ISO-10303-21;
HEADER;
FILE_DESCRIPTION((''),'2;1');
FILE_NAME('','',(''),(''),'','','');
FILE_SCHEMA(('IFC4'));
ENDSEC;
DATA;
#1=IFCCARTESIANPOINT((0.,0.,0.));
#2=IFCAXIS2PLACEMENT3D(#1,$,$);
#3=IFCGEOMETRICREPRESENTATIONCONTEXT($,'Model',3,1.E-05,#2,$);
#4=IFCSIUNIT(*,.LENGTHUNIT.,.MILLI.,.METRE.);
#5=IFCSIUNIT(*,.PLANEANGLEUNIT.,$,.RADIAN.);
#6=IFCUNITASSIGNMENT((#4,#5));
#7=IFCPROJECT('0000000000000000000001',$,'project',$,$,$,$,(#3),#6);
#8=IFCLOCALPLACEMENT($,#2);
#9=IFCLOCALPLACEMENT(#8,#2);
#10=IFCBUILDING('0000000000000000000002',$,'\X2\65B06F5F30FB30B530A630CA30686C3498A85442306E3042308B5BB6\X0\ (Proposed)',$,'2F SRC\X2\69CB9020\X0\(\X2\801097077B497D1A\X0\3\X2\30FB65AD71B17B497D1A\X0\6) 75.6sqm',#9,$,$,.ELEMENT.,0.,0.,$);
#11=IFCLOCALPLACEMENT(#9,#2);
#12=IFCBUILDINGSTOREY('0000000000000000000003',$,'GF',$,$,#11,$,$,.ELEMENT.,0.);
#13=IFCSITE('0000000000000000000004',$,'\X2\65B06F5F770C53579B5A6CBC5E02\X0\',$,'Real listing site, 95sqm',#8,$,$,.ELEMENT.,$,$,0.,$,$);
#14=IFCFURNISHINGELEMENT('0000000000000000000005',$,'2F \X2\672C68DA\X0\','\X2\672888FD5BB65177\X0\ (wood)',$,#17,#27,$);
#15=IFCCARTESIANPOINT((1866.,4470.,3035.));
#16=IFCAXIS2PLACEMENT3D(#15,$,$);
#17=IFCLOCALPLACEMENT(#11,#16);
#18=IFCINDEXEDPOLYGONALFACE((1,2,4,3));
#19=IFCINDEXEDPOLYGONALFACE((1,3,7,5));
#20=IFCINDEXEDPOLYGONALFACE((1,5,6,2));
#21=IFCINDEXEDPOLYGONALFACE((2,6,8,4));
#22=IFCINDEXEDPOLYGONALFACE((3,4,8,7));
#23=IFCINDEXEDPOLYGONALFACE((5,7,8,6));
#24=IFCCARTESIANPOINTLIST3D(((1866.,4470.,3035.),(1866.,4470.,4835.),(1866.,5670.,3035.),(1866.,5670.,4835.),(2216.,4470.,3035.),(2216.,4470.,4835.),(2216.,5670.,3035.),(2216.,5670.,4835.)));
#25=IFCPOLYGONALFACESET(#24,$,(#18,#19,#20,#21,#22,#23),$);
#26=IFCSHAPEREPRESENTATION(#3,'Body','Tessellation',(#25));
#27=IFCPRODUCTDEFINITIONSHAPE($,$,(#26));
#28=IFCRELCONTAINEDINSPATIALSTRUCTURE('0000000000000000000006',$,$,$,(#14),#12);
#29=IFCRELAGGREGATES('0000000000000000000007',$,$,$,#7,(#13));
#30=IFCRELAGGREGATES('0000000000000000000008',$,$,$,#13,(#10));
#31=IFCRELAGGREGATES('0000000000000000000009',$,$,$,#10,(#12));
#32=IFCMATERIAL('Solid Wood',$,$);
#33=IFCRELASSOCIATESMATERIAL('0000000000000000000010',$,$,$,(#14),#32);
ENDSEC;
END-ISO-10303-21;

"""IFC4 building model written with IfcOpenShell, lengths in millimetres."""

from ifc_helpers import new_model, si_unit, frame, frame_2d, origin, place, context, project, spatial, rectangle, extrude, material, element, save


model = new_model("IFC4")

# Units and contexts
model_context = context("Model", 3, precision=1e-05, world=origin())
ifc_project = project(units=[si_unit("LENGTHUNIT", "METRE", prefix="MILLI"), si_unit("PLANEANGLEUNIT", "RADIAN")], contexts=[model_context])

# Site, building, storey
site_placement = place(None, origin())
site = spatial("IfcSite", under=ifc_project, at=site_placement, Name="新潟県南魚沼市", ObjectType="Real listing site, 95sqm", CompositionType="ELEMENT", RefElevation=0.0)
building_placement = place(site_placement, origin())
building = spatial("IfcBuilding", under=site, at=building_placement, Name="新潟・サウナと水風呂のある家 (Proposed)", ObjectType="2F SRC構造(耐震等級3・断熱等級6) 75.6sqm", CompositionType="ELEMENT", ElevationOfRefHeight=0.0, ElevationOfTerrain=0.0)
storey_placement = place(building_placement, origin())
storey = spatial("IfcBuildingStorey", under=building, at=storey_placement, Name="GF", CompositionType="ELEMENT", Elevation=0.0)

# Shared definitions
ifc_material_1 = material(Name="Solid Wood")

# Furnishing element
furnishing_placement = place(storey_placement, frame((1866.0, 4470.0, 3035.0)))
element("IfcFurnishingElement", 1, at=furnishing_placement, inside=storey, material=ifc_material_1, Name="2F 本棚", Description="木製家具 (wood)", context=model_context, shape_type="SweptSolid", body=[
    extrude(rectangle(XDim=350.0, YDim=1200.0, at=frame_2d((175.0, 600.0))), frame((1866.0, 4470.0, 3035.0)), (0.0, 0.0, 1.0), 1800.0),
])

save(model, "model.ifc")
